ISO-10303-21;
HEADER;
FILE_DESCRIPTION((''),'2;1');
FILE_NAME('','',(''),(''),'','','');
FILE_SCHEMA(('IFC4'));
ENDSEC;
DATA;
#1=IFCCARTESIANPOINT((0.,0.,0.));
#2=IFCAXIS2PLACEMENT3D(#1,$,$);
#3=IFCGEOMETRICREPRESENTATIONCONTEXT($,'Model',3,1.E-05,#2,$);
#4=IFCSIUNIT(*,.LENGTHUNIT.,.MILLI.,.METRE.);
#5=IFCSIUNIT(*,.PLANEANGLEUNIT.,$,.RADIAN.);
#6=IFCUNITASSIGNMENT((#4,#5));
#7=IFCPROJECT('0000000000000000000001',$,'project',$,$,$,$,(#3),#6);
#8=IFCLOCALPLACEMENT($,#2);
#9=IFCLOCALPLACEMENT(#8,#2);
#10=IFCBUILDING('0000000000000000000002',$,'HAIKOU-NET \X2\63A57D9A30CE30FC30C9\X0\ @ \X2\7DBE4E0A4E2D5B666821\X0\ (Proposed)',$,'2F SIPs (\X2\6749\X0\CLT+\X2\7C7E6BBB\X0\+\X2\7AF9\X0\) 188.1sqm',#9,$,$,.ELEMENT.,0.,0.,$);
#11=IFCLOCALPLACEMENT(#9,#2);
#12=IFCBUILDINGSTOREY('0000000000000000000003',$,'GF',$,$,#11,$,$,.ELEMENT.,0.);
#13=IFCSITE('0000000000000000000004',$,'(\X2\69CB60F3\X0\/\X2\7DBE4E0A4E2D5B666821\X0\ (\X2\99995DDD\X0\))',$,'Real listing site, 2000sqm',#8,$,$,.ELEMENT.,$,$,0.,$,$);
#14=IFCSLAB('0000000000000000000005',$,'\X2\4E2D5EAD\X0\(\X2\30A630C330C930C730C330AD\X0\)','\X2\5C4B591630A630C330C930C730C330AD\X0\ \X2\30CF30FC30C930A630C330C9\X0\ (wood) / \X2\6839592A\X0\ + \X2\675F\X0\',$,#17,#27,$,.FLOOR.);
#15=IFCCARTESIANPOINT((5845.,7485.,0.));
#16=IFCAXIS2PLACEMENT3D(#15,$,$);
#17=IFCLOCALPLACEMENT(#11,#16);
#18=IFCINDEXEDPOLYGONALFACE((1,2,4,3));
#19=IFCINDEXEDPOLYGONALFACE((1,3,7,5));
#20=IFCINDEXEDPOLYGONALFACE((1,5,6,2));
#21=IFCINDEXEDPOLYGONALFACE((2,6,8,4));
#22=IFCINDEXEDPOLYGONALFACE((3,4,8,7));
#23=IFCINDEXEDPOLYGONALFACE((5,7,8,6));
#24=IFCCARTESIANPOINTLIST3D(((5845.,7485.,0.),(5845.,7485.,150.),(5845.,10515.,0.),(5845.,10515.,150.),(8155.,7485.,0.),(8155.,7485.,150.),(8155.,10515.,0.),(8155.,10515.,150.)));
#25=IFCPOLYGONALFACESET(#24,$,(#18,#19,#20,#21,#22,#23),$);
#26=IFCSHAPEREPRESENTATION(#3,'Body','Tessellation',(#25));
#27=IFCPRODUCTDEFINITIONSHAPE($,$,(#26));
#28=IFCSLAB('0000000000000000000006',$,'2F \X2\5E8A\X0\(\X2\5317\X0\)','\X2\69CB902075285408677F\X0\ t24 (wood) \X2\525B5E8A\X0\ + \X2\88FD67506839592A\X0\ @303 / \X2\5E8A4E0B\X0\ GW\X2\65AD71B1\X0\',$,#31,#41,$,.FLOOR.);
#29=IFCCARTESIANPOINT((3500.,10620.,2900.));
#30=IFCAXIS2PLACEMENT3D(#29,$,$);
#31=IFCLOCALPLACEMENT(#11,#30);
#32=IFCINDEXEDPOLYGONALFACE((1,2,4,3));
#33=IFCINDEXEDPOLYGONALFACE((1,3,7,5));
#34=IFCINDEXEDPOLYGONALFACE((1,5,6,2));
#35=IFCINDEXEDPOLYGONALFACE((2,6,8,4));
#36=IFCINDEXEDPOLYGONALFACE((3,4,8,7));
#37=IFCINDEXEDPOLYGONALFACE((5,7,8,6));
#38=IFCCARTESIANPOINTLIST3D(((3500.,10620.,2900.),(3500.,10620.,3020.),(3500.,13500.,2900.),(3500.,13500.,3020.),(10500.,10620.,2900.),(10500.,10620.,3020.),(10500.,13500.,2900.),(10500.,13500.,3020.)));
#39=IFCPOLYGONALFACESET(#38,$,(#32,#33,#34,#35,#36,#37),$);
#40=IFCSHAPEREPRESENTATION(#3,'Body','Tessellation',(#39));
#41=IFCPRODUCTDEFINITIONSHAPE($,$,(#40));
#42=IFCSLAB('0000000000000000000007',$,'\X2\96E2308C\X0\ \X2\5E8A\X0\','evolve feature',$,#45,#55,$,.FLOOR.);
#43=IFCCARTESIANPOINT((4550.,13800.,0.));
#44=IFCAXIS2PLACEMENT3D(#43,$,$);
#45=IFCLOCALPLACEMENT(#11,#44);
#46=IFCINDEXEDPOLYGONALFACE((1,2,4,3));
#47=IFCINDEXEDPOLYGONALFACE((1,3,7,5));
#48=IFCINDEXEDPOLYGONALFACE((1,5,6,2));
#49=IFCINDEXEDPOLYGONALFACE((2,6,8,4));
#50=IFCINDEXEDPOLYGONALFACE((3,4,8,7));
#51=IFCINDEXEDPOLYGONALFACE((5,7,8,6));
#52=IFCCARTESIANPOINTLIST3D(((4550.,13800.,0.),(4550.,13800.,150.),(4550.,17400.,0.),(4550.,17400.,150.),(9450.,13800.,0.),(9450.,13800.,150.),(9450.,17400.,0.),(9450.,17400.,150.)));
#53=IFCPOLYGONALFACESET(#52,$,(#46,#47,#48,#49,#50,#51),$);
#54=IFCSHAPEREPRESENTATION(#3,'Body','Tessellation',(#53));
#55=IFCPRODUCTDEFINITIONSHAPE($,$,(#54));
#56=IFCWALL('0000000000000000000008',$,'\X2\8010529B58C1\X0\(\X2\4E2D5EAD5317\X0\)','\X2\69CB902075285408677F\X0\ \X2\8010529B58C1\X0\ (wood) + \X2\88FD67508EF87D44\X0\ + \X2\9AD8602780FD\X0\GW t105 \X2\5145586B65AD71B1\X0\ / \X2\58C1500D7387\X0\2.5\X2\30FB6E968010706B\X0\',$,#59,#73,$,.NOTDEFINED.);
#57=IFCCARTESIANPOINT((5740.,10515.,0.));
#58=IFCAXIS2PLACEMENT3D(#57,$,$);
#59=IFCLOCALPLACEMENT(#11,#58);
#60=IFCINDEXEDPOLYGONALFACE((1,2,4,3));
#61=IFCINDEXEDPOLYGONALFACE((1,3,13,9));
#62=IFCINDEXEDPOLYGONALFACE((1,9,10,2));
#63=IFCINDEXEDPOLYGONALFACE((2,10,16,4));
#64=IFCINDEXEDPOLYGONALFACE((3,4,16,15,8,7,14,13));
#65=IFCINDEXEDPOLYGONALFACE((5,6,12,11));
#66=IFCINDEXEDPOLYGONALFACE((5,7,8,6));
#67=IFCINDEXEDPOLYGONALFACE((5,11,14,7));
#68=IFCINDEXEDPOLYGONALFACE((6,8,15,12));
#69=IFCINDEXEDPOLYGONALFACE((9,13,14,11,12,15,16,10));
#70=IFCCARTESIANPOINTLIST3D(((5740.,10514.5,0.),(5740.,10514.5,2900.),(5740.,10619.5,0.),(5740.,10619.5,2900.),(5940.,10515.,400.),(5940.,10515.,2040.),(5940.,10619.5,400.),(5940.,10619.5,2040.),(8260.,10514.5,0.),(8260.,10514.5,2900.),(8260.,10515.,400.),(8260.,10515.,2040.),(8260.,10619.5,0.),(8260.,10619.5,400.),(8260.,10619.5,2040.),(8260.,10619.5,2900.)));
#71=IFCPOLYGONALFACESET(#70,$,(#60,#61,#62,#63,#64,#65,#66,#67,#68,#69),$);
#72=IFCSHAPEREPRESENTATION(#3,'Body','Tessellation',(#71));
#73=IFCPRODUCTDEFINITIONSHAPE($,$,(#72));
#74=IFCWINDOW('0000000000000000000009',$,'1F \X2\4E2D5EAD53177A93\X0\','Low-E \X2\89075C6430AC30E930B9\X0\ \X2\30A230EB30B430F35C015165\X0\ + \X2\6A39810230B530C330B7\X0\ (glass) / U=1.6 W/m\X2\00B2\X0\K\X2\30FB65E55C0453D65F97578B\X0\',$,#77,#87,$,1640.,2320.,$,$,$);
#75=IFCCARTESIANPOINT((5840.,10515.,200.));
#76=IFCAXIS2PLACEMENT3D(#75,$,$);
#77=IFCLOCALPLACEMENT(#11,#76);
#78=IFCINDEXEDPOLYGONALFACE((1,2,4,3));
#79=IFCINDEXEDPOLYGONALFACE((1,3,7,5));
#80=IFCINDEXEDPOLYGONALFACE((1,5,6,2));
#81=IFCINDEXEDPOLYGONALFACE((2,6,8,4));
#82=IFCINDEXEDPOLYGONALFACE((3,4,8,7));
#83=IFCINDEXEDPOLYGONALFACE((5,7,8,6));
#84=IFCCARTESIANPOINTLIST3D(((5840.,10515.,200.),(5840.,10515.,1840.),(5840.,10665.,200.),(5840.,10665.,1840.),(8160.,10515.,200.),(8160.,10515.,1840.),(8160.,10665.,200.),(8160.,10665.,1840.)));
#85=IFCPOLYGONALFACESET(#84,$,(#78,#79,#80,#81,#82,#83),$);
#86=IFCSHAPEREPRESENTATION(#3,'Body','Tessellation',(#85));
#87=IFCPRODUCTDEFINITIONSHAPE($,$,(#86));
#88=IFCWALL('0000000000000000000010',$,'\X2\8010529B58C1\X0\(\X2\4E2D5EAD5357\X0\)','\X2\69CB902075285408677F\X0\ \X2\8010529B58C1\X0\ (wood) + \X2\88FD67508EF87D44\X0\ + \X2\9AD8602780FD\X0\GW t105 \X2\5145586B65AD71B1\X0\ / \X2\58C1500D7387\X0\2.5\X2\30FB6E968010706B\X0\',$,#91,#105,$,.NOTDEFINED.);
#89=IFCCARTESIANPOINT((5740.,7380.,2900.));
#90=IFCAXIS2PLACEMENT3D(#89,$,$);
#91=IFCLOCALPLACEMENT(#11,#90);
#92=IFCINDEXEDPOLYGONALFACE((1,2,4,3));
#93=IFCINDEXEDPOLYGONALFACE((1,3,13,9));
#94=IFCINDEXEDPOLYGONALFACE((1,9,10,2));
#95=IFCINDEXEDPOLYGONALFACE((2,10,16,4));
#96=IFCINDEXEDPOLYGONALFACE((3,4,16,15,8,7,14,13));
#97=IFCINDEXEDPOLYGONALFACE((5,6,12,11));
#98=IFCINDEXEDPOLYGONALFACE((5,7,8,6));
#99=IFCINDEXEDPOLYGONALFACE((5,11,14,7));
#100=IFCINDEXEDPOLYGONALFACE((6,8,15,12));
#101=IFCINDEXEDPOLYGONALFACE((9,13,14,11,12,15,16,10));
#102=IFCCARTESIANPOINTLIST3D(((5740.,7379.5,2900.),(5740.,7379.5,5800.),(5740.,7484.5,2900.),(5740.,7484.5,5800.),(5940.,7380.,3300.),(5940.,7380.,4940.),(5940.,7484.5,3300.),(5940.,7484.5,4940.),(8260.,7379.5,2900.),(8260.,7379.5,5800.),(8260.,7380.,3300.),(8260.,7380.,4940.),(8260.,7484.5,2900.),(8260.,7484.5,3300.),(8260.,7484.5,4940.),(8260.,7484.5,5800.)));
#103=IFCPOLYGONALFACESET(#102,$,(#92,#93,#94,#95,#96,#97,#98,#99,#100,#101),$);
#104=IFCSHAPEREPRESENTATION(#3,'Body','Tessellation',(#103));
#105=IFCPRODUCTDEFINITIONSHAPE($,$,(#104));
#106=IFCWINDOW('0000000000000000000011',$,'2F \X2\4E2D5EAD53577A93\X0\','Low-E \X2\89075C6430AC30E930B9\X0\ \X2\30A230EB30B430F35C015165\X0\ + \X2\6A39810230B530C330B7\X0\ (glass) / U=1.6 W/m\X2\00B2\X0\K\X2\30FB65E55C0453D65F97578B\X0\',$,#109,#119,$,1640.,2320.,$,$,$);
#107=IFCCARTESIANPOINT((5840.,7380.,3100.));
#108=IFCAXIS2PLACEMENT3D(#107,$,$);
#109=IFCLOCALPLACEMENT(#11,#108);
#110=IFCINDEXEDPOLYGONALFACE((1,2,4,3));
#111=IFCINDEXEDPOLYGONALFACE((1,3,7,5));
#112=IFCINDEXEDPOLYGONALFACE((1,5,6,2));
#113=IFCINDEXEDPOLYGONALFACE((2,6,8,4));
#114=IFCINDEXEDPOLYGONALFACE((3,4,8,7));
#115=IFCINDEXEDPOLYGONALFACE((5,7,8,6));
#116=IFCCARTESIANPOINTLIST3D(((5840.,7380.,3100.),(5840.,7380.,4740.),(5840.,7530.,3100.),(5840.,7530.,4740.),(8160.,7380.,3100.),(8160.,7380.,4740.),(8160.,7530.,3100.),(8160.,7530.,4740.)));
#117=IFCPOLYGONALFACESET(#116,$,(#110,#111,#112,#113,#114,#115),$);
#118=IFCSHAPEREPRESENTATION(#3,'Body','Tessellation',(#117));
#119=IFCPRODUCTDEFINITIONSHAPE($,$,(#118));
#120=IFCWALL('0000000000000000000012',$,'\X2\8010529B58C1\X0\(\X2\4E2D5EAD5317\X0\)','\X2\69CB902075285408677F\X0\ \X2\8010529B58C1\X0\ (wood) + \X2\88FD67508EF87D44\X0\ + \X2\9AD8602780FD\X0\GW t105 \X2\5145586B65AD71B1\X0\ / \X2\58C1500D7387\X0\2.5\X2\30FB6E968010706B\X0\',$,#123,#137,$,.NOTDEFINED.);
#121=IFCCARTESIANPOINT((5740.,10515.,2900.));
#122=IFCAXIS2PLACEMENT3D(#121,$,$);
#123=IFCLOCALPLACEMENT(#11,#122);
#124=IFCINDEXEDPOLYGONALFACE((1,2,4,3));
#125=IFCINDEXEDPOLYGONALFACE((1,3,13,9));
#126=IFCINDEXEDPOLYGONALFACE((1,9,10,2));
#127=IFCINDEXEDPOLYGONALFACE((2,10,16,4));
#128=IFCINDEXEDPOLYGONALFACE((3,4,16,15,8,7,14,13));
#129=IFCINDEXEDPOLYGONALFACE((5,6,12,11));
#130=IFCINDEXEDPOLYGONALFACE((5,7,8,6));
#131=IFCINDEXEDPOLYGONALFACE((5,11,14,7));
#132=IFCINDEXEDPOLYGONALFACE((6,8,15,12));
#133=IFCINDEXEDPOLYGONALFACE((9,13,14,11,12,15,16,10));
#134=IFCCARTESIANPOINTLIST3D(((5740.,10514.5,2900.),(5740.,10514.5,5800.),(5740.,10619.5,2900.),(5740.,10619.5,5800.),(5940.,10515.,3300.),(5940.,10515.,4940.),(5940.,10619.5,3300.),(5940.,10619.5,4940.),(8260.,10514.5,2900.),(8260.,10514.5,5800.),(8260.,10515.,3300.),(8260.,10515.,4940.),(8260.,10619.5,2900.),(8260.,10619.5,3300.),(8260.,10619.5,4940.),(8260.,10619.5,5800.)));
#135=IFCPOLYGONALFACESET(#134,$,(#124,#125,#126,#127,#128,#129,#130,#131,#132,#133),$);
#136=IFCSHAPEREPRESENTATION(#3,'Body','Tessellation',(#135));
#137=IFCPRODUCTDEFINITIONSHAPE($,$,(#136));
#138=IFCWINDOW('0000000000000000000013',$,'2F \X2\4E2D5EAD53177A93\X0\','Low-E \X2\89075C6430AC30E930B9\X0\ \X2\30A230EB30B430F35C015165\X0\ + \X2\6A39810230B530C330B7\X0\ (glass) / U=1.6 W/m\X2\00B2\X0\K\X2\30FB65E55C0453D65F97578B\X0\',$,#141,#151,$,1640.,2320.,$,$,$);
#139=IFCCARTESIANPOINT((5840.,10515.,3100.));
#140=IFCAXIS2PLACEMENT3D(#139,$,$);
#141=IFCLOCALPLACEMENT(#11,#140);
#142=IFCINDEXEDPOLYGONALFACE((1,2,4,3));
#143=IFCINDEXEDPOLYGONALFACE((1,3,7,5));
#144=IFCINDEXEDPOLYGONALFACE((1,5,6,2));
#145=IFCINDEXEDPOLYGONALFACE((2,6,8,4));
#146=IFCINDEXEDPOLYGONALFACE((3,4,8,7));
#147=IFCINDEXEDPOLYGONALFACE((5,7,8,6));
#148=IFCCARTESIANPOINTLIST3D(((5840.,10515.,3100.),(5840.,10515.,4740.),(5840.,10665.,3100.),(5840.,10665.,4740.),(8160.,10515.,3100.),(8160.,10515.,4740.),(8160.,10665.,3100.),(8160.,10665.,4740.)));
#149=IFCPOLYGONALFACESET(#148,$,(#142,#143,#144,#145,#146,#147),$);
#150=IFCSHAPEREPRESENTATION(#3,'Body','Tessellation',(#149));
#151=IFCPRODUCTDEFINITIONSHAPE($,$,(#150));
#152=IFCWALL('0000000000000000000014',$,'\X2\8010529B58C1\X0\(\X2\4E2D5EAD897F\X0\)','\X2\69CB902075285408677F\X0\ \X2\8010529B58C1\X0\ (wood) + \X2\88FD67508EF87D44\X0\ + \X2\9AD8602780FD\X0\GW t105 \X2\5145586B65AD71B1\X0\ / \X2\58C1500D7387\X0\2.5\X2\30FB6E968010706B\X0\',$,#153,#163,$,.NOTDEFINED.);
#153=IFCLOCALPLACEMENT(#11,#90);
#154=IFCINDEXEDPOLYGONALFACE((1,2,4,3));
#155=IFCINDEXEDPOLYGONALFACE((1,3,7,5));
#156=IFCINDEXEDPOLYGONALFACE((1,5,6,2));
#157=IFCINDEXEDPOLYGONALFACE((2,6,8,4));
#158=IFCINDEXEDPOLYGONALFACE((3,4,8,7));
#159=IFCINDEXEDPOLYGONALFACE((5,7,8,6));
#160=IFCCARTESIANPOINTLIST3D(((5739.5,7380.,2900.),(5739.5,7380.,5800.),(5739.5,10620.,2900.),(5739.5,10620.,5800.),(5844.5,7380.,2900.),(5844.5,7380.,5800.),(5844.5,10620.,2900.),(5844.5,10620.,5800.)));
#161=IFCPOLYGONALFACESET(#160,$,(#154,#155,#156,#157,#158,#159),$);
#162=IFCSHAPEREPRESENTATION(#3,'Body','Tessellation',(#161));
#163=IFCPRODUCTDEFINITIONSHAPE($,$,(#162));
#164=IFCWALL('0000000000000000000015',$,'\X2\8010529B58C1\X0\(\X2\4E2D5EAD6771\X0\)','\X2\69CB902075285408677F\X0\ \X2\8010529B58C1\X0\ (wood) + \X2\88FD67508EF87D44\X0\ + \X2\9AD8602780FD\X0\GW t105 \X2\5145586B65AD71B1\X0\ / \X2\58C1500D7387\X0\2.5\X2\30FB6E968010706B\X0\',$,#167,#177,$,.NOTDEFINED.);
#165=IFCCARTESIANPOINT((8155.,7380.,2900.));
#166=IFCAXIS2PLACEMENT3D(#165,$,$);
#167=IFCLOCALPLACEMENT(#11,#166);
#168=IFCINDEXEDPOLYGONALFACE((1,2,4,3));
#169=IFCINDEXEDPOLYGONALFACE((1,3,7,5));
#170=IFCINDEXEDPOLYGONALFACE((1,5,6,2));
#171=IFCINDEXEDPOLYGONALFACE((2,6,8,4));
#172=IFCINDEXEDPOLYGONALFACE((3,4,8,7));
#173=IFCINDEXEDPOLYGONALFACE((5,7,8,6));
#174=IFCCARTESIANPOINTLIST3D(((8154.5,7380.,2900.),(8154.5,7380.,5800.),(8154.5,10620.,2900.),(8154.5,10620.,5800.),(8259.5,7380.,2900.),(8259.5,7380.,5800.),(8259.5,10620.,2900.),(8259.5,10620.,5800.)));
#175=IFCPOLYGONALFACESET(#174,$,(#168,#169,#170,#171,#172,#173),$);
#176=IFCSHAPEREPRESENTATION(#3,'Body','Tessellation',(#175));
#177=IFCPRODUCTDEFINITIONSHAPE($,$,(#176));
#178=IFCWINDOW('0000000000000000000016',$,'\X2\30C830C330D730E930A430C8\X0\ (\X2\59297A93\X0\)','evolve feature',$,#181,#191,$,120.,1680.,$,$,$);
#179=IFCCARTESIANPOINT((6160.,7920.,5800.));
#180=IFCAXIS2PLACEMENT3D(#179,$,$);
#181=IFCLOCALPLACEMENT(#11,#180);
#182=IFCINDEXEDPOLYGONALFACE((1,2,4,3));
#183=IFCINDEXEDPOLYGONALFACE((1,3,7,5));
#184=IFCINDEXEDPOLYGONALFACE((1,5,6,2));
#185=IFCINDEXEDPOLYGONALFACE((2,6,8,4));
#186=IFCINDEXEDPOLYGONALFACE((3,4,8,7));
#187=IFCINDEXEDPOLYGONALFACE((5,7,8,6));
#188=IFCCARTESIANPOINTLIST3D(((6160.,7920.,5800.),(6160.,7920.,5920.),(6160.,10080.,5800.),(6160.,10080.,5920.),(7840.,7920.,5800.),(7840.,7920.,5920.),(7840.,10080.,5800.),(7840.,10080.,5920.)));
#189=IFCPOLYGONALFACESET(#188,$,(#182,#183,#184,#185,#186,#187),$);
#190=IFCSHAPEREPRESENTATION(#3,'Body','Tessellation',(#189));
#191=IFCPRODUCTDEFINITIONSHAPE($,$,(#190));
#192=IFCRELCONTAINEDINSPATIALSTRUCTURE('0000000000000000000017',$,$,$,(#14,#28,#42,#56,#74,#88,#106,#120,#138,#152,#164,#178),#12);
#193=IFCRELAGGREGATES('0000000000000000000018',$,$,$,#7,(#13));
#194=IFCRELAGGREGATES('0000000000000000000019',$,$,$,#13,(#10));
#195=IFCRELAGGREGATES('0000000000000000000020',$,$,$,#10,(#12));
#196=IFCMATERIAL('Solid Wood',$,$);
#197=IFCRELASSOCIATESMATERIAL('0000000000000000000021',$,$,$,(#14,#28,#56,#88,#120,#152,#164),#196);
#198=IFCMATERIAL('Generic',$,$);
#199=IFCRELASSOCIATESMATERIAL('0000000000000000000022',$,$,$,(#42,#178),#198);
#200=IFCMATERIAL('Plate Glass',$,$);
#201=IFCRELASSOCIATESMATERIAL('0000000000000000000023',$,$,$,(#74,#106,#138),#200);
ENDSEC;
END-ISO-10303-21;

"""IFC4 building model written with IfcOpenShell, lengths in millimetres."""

from ifc_helpers import new_model, si_unit, frame, frame_2d, origin, place, context, project, spatial, rectangle, extrude, material, element, fill, save


model = new_model("IFC4")

# Units and contexts
model_context = context("Model", 3, precision=1e-05, world=origin())
ifc_project = project(units=[si_unit("LENGTHUNIT", "METRE", prefix="MILLI"), si_unit("PLANEANGLEUNIT", "RADIAN")], contexts=[model_context])

# Site, building, storey
site_placement = place(None, origin())
site = spatial("IfcSite", under=ifc_project, at=site_placement, Name="(構想/綾上中学校 (香川))", ObjectType="Real listing site, 2000sqm", CompositionType="ELEMENT", RefElevation=0.0)
building_placement = place(site_placement, origin())
building = spatial("IfcBuilding", under=site, at=building_placement, Name="HAIKOU-NET 接続ノード @ 綾上中学校 (Proposed)", ObjectType="2F SIPs (杉CLT+籾殻+竹) 188.1sqm", CompositionType="ELEMENT", ElevationOfRefHeight=0.0, ElevationOfTerrain=0.0)
storey_placement = place(building_placement, origin())
storey = spatial("IfcBuildingStorey", under=building, at=storey_placement, Name="GF", CompositionType="ELEMENT", Elevation=0.0)

# Slabs
ifc_material_1 = material(Name="Solid Wood")
slab_1_placement = place(storey_placement, frame((5845.0, 7485.0, 0.0)))
element("IfcSlab", 1, at=slab_1_placement, inside=storey, material=ifc_material_1, Name="中庭(ウッドデッキ)", Description="屋外ウッドデッキ ハードウッド (wood) / 根太 + 束", PredefinedType="FLOOR", context=model_context, shape_type="SweptSolid", body=[
    extrude(rectangle(XDim=2310.0, YDim=3030.0, at=frame_2d((1155.0, 1515.0))), frame((5845.0, 7485.0, 0.0)), (0.0, 0.0, 1.0), 150.0),
])
slab_2_placement = place(storey_placement, frame((3500.0, 10620.0, 2900.0)))
element("IfcSlab", 2, at=slab_2_placement, inside=storey, material=ifc_material_1, Name="2F 床(北)", Description="構造用合板 t24 (wood) 剛床 + 製材根太 @303 / 床下 GW断熱", PredefinedType="FLOOR", context=model_context, shape_type="SweptSolid", body=[
    extrude(rectangle(XDim=7000.0, YDim=2880.0, at=frame_2d((3500.0, 1440.0))), frame((3500.0, 10620.0, 2900.0)), (0.0, 0.0, 1.0), 120.0),
])
ifc_material_2 = material(Name="Generic")
slab_3_placement = place(storey_placement, frame((4550.0, 13800.0, 0.0)))
element("IfcSlab", 3, at=slab_3_placement, inside=storey, material=ifc_material_2, Name="離れ 床", Description="evolve feature", PredefinedType="FLOOR", context=model_context, shape_type="SweptSolid", body=[
    extrude(rectangle(XDim=4900.0, YDim=3600.0, at=frame_2d((2450.0, 1800.0))), frame((4550.0, 13800.0, 0.0)), (0.0, 0.0, 1.0), 150.0),
])

# Wall, opening, window
wall_1_placement = place(storey_placement, frame((5740.0, 10515.0, 0.0)))
wall_1 = element("IfcWall", 4, at=wall_1_placement, inside=storey, material=ifc_material_1, Name="耐力壁(中庭北)", Description="構造用合板 耐力壁 (wood) + 製材軸組 + 高性能GW t105 充填断熱 / 壁倍率2.5・準耐火", PredefinedType="NOTDEFINED", context=model_context, shape_type="SweptSolid", body=[
    extrude(rectangle(XDim=2520.0, YDim=105.0, at=frame_2d((1260.0, 52.0))), frame((5740.0, 10515.0, 0.0)), (0.0, 0.0, 1.0), 2900.0),
])
opening_1_placement = place(storey_placement, frame((5840.0, 10515.0, 200.0)))
opening_1 = element("IfcOpeningElement", 5, at=opening_1_placement, cuts=wall_1, PredefinedType="NOTDEFINED", context=model_context, shape_type="SweptSolid", body=[
    extrude(rectangle(XDim=2320.0, YDim=150.0, at=frame_2d((1160.0, 75.0))), frame((5840.0, 10515.0, 200.0)), (0.0, 0.0, 1.0), 1640.0),
])
ifc_material_3 = material(Name="Plate Glass")
window_1_placement = place(storey_placement, frame((5840.0, 10515.0, 200.0)))
window_1 = element("IfcWindow", 6, at=window_1_placement, inside=storey, material=ifc_material_3, Name="1F 中庭北窓", Description="Low-E 複層ガラス アルゴン封入 + 樹脂サッシ (glass) / U=1.6 W/m²K・日射取得型", OverallHeight=1640.0, OverallWidth=2320.0, context=model_context, shape_type="SweptSolid", body=[
    extrude(rectangle(XDim=2320.0, YDim=150.0, at=frame_2d((1160.0, 75.0))), frame((5840.0, 10515.0, 200.0)), (0.0, 0.0, 1.0), 1640.0),
])
fill(opening_1, window_1)

# Walls, openings, windows
wall_2_placement = place(storey_placement, frame((5740.0, 7380.0, 2900.0)))
wall_2 = element("IfcWall", 7, at=wall_2_placement, inside=storey, material=ifc_material_1, Name="耐力壁(中庭南)", Description="構造用合板 耐力壁 (wood) + 製材軸組 + 高性能GW t105 充填断熱 / 壁倍率2.5・準耐火", PredefinedType="NOTDEFINED", context=model_context, shape_type="SweptSolid", body=[
    extrude(rectangle(XDim=2520.0, YDim=105.0, at=frame_2d((1260.0, 52.0))), frame((5740.0, 7380.0, 2900.0)), (0.0, 0.0, 1.0), 2900.0),
])
opening_2_placement = place(storey_placement, frame((5840.0, 7380.0, 3100.0)))
opening_2 = element("IfcOpeningElement", 8, at=opening_2_placement, cuts=wall_2, PredefinedType="NOTDEFINED", context=model_context, shape_type="SweptSolid", body=[
    extrude(rectangle(XDim=2320.0, YDim=150.0, at=frame_2d((1160.0, 75.0))), frame((5840.0, 7380.0, 3100.0)), (0.0, 0.0, 1.0), 1640.0),
])
window_2_placement = place(storey_placement, frame((5840.0, 7380.0, 3100.0)))
window_2 = element("IfcWindow", 9, at=window_2_placement, inside=storey, material=ifc_material_3, Name="2F 中庭南窓", Description="Low-E 複層ガラス アルゴン封入 + 樹脂サッシ (glass) / U=1.6 W/m²K・日射取得型", OverallHeight=1640.0, OverallWidth=2320.0, context=model_context, shape_type="SweptSolid", body=[
    extrude(rectangle(XDim=2320.0, YDim=150.0, at=frame_2d((1160.0, 75.0))), frame((5840.0, 7380.0, 3100.0)), (0.0, 0.0, 1.0), 1640.0),
])
fill(opening_2, window_2)
wall_3_placement = place(storey_placement, frame((5740.0, 10515.0, 2900.0)))
wall_3 = element("IfcWall", 10, at=wall_3_placement, inside=storey, material=ifc_material_1, Name="耐力壁(中庭北)", Description="構造用合板 耐力壁 (wood) + 製材軸組 + 高性能GW t105 充填断熱 / 壁倍率2.5・準耐火", PredefinedType="NOTDEFINED", context=model_context, shape_type="SweptSolid", body=[
    extrude(rectangle(XDim=2520.0, YDim=105.0, at=frame_2d((1260.0, 52.0))), frame((5740.0, 10515.0, 2900.0)), (0.0, 0.0, 1.0), 2900.0),
])
opening_3_placement = place(storey_placement, frame((5840.0, 10515.0, 3100.0)))
opening_3 = element("IfcOpeningElement", 11, at=opening_3_placement, cuts=wall_3, PredefinedType="NOTDEFINED", context=model_context, shape_type="SweptSolid", body=[
    extrude(rectangle(XDim=2320.0, YDim=150.0, at=frame_2d((1160.0, 75.0))), frame((5840.0, 10515.0, 3100.0)), (0.0, 0.0, 1.0), 1640.0),
])
window_3_placement = place(storey_placement, frame((5840.0, 10515.0, 3100.0)))
window_3 = element("IfcWindow", 12, at=window_3_placement, inside=storey, material=ifc_material_3, Name="2F 中庭北窓", Description="Low-E 複層ガラス アルゴン封入 + 樹脂サッシ (glass) / U=1.6 W/m²K・日射取得型", OverallHeight=1640.0, OverallWidth=2320.0, context=model_context, shape_type="SweptSolid", body=[
    extrude(rectangle(XDim=2320.0, YDim=150.0, at=frame_2d((1160.0, 75.0))), frame((5840.0, 10515.0, 3100.0)), (0.0, 0.0, 1.0), 1640.0),
])
fill(opening_3, window_3)

# Walls
wall_4_placement = place(storey_placement, frame((5740.0, 7380.0, 2900.0)))
element("IfcWall", 13, at=wall_4_placement, inside=storey, material=ifc_material_1, Name="耐力壁(中庭西)", Description="構造用合板 耐力壁 (wood) + 製材軸組 + 高性能GW t105 充填断熱 / 壁倍率2.5・準耐火", PredefinedType="NOTDEFINED", context=model_context, shape_type="SweptSolid", body=[
    extrude(rectangle(XDim=105.0, YDim=3240.0, at=frame_2d((52.0, 1620.0))), frame((5740.0, 7380.0, 2900.0)), (0.0, 0.0, 1.0), 2900.0),
])
wall_5_placement = place(storey_placement, frame((8155.0, 7380.0, 2900.0)))
element("IfcWall", 14, at=wall_5_placement, inside=storey, material=ifc_material_1, Name="耐力壁(中庭東)", Description="構造用合板 耐力壁 (wood) + 製材軸組 + 高性能GW t105 充填断熱 / 壁倍率2.5・準耐火", PredefinedType="NOTDEFINED", context=model_context, shape_type="SweptSolid", body=[
    extrude(rectangle(XDim=105.0, YDim=3240.0, at=frame_2d((52.0, 1620.0))), frame((8155.0, 7380.0, 2900.0)), (0.0, 0.0, 1.0), 2900.0),
])

# Window
window_4_placement = place(storey_placement, frame((6160.0, 7920.0, 5800.0)))
element("IfcWindow", 15, at=window_4_placement, inside=storey, material=ifc_material_2, Name="トップライト (天窓)", Description="evolve feature", OverallHeight=120.0, OverallWidth=1680.0, context=model_context, shape_type="SweptSolid", body=[
    extrude(rectangle(XDim=1680.0, YDim=2160.0, at=frame_2d((840.0, 1080.0))), frame((6160.0, 7920.0, 5800.0)), (0.0, 0.0, 1.0), 120.0),
])

save(model, "model.ifc")
